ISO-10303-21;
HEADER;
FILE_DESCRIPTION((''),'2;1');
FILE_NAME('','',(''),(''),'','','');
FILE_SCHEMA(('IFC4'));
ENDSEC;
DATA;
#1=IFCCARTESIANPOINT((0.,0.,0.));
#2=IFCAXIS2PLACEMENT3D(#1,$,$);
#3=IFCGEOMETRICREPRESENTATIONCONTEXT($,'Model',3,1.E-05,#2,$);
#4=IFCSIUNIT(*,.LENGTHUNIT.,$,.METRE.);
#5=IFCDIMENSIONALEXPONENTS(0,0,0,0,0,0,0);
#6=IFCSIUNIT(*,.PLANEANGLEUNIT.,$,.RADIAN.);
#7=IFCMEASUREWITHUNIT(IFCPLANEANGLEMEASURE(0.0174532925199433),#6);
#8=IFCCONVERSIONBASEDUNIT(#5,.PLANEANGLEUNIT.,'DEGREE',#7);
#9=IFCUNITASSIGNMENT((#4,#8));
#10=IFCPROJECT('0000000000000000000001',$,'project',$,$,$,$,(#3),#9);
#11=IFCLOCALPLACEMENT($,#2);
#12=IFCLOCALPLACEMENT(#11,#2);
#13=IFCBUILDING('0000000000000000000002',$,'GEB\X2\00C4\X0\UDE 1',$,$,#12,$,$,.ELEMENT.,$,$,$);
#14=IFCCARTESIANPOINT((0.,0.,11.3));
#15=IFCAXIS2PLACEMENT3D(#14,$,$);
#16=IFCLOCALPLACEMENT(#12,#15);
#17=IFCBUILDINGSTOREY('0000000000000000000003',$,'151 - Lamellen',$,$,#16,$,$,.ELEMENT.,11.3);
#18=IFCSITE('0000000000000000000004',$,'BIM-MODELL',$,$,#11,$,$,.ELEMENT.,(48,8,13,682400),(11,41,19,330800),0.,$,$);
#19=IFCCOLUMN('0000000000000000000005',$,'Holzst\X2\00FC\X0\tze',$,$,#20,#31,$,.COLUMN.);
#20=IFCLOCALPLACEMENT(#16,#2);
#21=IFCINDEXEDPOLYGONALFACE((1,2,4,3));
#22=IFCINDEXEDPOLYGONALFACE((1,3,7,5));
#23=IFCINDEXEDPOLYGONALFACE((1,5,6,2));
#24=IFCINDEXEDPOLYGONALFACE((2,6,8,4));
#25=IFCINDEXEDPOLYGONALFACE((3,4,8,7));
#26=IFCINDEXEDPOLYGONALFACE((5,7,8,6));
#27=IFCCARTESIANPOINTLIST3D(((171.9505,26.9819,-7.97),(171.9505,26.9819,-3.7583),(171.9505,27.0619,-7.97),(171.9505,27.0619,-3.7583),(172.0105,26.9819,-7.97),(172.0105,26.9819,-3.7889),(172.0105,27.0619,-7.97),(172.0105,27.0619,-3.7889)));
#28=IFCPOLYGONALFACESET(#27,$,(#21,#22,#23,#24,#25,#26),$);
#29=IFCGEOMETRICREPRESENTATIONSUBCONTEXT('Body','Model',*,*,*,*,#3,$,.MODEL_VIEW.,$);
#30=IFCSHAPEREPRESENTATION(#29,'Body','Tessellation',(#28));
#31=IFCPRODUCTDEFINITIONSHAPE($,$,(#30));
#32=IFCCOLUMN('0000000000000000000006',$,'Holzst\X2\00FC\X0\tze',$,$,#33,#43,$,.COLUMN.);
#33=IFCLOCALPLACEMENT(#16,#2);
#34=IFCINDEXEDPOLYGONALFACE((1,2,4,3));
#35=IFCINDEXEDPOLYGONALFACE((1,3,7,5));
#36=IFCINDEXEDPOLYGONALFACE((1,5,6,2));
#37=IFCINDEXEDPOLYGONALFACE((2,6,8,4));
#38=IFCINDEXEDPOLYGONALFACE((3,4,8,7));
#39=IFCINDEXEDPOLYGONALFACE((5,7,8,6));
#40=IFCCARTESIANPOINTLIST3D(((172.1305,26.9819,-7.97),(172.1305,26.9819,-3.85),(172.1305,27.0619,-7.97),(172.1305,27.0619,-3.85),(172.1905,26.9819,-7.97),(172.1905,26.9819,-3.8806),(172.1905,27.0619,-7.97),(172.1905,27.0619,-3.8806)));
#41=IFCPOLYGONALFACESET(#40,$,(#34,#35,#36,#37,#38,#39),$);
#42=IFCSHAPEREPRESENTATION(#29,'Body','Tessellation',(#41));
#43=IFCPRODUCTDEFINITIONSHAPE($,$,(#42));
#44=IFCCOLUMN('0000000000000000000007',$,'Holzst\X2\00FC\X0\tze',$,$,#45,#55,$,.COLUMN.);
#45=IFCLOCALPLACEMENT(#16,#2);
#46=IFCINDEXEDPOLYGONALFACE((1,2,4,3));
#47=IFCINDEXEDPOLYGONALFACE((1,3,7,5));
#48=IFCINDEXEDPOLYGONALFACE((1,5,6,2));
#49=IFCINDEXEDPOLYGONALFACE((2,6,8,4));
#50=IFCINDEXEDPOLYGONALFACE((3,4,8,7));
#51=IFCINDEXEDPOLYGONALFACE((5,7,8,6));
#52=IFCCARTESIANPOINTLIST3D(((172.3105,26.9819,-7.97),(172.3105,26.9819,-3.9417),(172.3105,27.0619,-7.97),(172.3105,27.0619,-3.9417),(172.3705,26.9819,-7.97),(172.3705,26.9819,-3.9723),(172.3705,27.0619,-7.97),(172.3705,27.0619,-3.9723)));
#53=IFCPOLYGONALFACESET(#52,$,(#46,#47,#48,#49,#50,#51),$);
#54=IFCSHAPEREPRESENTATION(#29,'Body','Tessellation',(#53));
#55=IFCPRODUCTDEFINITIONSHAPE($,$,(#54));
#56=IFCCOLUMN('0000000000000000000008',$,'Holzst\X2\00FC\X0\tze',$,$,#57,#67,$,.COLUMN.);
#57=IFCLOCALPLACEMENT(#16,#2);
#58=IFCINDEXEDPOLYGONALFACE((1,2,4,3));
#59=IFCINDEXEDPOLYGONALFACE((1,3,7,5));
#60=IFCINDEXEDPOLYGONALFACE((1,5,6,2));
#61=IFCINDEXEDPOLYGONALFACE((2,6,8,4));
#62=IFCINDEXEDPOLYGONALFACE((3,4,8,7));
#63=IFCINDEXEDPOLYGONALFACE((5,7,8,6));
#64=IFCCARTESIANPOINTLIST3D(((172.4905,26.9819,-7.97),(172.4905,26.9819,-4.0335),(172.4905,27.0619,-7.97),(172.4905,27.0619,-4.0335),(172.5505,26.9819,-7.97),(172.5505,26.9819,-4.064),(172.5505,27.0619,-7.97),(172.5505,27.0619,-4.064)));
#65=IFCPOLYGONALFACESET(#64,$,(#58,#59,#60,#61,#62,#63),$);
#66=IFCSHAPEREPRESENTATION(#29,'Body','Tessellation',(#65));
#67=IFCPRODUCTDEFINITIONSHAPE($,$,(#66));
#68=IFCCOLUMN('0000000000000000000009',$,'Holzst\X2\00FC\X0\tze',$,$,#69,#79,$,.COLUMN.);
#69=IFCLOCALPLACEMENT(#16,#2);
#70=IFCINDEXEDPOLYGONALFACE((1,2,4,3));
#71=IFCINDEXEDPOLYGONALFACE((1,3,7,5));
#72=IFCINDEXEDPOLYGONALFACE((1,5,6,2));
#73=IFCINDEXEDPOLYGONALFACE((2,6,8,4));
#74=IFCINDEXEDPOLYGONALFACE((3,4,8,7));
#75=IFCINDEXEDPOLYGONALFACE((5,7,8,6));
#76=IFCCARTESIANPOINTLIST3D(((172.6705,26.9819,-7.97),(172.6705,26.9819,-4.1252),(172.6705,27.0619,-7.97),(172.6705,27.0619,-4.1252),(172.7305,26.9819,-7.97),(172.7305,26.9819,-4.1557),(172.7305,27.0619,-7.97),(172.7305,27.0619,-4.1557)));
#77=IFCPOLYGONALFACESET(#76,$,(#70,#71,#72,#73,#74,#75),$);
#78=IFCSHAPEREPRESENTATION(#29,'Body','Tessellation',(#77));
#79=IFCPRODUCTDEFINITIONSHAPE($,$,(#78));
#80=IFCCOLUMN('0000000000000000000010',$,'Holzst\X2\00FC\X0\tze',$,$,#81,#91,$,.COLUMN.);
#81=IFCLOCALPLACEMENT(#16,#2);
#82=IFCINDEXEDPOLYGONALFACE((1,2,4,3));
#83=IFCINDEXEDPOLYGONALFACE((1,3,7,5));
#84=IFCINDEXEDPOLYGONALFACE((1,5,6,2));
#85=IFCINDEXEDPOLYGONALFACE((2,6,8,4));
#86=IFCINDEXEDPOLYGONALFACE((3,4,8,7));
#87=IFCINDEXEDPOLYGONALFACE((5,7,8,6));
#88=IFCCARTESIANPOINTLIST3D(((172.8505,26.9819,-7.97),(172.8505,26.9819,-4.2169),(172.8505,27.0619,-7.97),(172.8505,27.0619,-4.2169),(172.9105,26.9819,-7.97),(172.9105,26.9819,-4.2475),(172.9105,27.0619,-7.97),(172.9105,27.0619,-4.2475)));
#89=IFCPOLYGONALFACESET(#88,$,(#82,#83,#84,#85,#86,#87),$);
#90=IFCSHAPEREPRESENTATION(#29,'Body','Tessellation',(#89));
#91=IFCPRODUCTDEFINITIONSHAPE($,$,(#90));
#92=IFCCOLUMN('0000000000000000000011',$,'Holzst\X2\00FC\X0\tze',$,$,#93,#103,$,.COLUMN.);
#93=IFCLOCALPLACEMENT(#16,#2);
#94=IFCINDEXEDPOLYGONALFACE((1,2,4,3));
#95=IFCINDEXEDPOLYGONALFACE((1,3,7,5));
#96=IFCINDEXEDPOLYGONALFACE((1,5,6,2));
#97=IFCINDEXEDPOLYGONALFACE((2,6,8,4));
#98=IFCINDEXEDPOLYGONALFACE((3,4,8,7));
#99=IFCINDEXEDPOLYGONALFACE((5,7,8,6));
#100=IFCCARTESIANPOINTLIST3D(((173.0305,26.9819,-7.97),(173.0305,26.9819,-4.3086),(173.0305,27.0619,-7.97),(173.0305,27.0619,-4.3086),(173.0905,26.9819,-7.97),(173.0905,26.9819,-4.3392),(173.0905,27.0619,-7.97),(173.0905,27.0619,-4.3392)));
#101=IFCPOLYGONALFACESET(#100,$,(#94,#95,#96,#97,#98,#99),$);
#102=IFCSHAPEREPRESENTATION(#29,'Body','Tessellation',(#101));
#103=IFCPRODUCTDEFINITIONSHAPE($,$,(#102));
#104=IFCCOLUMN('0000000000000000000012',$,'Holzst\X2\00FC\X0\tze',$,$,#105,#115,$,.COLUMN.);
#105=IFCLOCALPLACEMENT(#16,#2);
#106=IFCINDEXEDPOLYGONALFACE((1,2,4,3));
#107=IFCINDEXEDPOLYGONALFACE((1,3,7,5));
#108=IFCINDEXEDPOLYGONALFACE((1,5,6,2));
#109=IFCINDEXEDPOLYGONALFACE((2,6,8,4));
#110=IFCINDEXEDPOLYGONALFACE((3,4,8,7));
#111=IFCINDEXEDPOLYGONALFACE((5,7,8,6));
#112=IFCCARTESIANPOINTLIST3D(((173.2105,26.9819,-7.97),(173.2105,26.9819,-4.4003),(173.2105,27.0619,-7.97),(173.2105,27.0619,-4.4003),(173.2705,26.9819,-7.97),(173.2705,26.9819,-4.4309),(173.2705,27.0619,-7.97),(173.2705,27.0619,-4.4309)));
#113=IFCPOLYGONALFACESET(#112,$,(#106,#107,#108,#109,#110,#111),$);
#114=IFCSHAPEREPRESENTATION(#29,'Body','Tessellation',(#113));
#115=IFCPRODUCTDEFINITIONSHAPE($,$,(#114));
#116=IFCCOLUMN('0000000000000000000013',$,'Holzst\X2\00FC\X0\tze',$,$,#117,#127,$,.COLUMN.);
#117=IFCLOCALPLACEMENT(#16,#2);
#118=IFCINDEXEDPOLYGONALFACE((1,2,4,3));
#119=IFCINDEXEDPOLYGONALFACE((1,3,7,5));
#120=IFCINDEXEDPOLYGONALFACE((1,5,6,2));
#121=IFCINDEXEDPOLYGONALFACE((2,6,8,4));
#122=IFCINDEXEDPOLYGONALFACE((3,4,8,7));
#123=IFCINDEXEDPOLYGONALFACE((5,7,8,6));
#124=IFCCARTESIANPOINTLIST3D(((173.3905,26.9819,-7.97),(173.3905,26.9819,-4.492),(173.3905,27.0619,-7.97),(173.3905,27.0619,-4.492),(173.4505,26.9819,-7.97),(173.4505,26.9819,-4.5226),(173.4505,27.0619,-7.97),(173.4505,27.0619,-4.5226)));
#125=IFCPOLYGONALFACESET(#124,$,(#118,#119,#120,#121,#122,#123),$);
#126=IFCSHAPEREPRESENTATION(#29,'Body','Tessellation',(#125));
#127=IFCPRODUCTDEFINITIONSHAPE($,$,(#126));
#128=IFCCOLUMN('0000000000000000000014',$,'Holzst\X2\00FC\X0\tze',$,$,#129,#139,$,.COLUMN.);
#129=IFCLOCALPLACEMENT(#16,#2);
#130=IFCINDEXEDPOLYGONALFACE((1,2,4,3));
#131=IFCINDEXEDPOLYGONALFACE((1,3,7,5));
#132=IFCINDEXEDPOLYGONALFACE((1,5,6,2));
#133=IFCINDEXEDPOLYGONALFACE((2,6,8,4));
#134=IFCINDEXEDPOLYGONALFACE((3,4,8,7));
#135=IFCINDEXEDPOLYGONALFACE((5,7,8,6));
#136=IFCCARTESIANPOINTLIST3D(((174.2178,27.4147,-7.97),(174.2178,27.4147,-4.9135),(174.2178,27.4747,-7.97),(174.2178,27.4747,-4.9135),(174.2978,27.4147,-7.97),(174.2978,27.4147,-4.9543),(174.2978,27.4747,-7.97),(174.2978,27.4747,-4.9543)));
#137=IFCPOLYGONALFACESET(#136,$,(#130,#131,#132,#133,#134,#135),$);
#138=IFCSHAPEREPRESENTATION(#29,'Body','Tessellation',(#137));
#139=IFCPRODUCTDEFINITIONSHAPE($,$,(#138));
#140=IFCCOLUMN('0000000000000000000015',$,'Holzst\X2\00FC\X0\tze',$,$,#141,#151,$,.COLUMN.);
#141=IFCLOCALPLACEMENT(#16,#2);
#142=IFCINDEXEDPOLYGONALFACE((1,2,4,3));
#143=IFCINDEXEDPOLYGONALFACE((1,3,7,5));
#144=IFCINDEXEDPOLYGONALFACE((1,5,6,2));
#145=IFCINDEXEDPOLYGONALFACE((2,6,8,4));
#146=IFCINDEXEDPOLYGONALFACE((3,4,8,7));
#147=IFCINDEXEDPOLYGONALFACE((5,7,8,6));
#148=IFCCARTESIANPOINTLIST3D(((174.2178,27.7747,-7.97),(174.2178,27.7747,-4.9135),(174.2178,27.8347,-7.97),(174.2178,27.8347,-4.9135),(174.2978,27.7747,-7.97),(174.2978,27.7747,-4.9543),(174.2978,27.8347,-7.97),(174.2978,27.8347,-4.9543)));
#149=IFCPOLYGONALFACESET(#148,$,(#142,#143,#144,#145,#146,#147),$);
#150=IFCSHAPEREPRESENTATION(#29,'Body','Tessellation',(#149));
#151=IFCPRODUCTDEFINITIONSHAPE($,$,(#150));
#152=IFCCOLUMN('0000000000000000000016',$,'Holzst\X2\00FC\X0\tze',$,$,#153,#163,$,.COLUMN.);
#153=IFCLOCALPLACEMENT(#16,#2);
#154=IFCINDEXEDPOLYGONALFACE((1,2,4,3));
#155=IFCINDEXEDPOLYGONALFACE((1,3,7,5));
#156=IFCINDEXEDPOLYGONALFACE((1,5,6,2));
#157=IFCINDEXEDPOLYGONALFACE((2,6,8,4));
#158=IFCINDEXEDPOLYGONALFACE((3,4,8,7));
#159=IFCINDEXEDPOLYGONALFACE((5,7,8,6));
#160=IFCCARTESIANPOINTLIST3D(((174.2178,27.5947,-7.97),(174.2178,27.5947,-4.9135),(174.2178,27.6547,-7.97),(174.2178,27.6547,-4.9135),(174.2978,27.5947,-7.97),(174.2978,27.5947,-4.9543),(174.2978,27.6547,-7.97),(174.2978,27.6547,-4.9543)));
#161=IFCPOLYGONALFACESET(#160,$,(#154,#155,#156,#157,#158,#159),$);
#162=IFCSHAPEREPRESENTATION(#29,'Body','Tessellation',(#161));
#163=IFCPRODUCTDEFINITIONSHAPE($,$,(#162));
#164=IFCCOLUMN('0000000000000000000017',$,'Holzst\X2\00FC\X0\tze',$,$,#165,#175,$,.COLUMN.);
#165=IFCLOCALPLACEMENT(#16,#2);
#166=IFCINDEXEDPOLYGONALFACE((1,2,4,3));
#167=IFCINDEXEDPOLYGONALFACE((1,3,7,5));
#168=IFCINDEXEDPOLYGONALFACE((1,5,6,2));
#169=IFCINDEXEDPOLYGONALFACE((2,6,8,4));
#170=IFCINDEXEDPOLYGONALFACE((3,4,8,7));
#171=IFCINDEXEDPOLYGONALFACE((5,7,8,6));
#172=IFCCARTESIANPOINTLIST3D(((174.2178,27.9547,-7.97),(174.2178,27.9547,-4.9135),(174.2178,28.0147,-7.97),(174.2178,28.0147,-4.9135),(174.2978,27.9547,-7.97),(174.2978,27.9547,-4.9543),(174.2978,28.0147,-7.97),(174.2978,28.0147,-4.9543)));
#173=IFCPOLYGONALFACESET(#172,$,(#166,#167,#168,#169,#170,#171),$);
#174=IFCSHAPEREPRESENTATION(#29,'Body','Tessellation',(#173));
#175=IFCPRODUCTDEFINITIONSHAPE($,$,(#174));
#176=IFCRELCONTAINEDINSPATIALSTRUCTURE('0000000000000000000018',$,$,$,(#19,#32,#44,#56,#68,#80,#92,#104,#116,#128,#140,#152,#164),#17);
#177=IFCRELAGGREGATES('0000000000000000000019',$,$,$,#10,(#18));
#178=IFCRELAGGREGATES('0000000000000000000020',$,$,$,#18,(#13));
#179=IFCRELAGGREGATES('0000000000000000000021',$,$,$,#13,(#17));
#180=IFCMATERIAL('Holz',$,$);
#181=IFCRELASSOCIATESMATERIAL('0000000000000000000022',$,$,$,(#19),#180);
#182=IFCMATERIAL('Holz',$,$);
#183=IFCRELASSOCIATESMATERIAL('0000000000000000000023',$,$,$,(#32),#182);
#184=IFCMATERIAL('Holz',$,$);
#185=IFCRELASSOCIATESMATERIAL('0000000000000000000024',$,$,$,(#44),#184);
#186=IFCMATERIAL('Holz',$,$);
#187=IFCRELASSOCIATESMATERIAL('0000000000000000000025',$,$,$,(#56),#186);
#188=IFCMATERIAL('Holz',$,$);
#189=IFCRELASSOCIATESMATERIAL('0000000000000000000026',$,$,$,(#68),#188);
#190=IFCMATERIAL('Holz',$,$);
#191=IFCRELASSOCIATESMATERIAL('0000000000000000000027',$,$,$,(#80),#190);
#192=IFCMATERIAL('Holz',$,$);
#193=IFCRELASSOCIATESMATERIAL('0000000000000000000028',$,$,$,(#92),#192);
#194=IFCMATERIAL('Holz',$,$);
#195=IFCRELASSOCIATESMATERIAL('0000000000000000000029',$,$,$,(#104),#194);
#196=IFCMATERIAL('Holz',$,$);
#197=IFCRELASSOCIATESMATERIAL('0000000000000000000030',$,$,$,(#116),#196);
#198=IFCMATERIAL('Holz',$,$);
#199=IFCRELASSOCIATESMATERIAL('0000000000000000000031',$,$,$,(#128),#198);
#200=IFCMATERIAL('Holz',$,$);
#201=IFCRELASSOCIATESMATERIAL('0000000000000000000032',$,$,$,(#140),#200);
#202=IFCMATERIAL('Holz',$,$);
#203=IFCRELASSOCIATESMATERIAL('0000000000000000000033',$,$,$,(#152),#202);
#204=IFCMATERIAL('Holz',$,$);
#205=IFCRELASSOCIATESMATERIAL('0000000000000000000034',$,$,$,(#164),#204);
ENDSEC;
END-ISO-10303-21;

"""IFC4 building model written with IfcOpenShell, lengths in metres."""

from ifc_helpers import new_model, entity, si_unit, converted_unit, frame, frame_2d, origin, origin_with_axes, place, context, subcontext, project, spatial, rectangle, extrude, clip, halfspace, material, element, save


model = new_model("IFC4")

# Units and contexts
model_context = context("Model", 3, precision=1e-05, world=origin())
body_context = subcontext(model_context, "Body", "Model", "MODEL_VIEW")
ifc_project = project(units=[si_unit("LENGTHUNIT", "METRE"), converted_unit("PLANEANGLEUNIT", "DEGREE", entity("IfcPlaneAngleMeasure", 0.0174532925199433), si_unit("PLANEANGLEUNIT", "RADIAN"), dimensions=[0, 0, 0, 0, 0, 0, 0])], contexts=[model_context])

# Site, building, storey
site_placement = place(None, origin())
site = spatial("IfcSite", under=ifc_project, at=site_placement, Name="BIM-MODELL", CompositionType="ELEMENT", RefLatitude=(48, 8, 13, 682400), RefLongitude=(11, 41, 19, 330800), RefElevation=0.0)
building_placement = place(site_placement, origin())
building = spatial("IfcBuilding", under=site, at=building_placement, Name="GEBÄUDE 1", CompositionType="ELEMENT")
storey_placement = place(building_placement, frame((0.0, 0.0, 11.3)))
storey = spatial("IfcBuildingStorey", under=building, at=storey_placement, Name="151 - Lamellen", CompositionType="ELEMENT", Elevation=11.3)

# Columns
ifc_material_1 = material(Name="Holz")
column_1_placement = place(storey_placement, frame((171.9505, 26.9819, -7.97)))
element("IfcColumn", 1, at=column_1_placement, inside=storey, material=ifc_material_1, Name="Holzstütze", PredefinedType="COLUMN", context=body_context, shape_type="Clipping", body=[
    clip(extrude(rectangle(XDim=0.06, YDim=0.08, at=frame_2d((0.03, 0.04), x_axis=(1.0, 0.0))), origin_with_axes(), (0.0, 0.0, 1.0), 4.2117), halfspace(frame((0.03, 0.04, 4.1964), z_axis=(-0.45399, 0.0, -0.891007), x_axis=(0.0, -1.0, 0.0)), True)),
])
ifc_material_2 = material(Name="Holz")
column_2_placement = place(storey_placement, frame((172.1305, 26.9819, -7.97)))
element("IfcColumn", 2, at=column_2_placement, inside=storey, material=ifc_material_2, Name="Holzstütze", PredefinedType="COLUMN", context=body_context, shape_type="Clipping", body=[
    clip(extrude(rectangle(XDim=0.06, YDim=0.08, at=frame_2d((0.03, 0.04), x_axis=(1.0, 0.0))), origin_with_axes(), (0.0, 0.0, 1.0), 4.12), halfspace(frame((0.03, 0.04, 4.1047), z_axis=(-0.45399, 0.0, -0.891007), x_axis=(0.0, -1.0, 0.0)), True)),
])
ifc_material_3 = material(Name="Holz")
column_3_placement = place(storey_placement, frame((172.3105, 26.9819, -7.97)))
element("IfcColumn", 3, at=column_3_placement, inside=storey, material=ifc_material_3, Name="Holzstütze", PredefinedType="COLUMN", context=body_context, shape_type="Clipping", body=[
    clip(extrude(rectangle(XDim=0.06, YDim=0.08, at=frame_2d((0.03, 0.04), x_axis=(1.0, 0.0))), origin_with_axes(), (0.0, 0.0, 1.0), 4.0283), halfspace(frame((0.03, 0.04, 4.013), z_axis=(-0.45399, 0.0, -0.891007), x_axis=(0.0, -1.0, 0.0)), True)),
])
ifc_material_4 = material(Name="Holz")
column_4_placement = place(storey_placement, frame((172.4905, 26.9819, -7.97)))
element("IfcColumn", 4, at=column_4_placement, inside=storey, material=ifc_material_4, Name="Holzstütze", PredefinedType="COLUMN", context=body_context, shape_type="Clipping", body=[
    clip(extrude(rectangle(XDim=0.06, YDim=0.08, at=frame_2d((0.03, 0.04), x_axis=(1.0, 0.0))), origin_with_axes(), (0.0, 0.0, 1.0), 3.9365), halfspace(frame((0.03, 0.04, 3.9213), z_axis=(-0.45399, 0.0, -0.891007), x_axis=(0.0, -1.0, 0.0)), True)),
])
ifc_material_5 = material(Name="Holz")
column_5_placement = place(storey_placement, frame((172.6705, 26.9819, -7.97)))
element("IfcColumn", 5, at=column_5_placement, inside=storey, material=ifc_material_5, Name="Holzstütze", PredefinedType="COLUMN", context=body_context, shape_type="Clipping", body=[
    clip(extrude(rectangle(XDim=0.06, YDim=0.08, at=frame_2d((0.03, 0.04), x_axis=(1.0, 0.0))), origin_with_axes(), (0.0, 0.0, 1.0), 3.8448), halfspace(frame((0.03, 0.04, 3.8295), z_axis=(-0.45399, 0.0, -0.891007), x_axis=(0.0, -1.0, 0.0)), True)),
])
ifc_material_6 = material(Name="Holz")
column_6_placement = place(storey_placement, frame((172.8505, 26.9819, -7.97)))
element("IfcColumn", 6, at=column_6_placement, inside=storey, material=ifc_material_6, Name="Holzstütze", PredefinedType="COLUMN", context=body_context, shape_type="Clipping", body=[
    clip(extrude(rectangle(XDim=0.06, YDim=0.08, at=frame_2d((0.03, 0.04), x_axis=(1.0, 0.0))), origin_with_axes(), (0.0, 0.0, 1.0), 3.7531), halfspace(frame((0.03, 0.04, 3.7378), z_axis=(-0.45399, 0.0, -0.891007), x_axis=(0.0, -1.0, 0.0)), True)),
])
ifc_material_7 = material(Name="Holz")
column_7_placement = place(storey_placement, frame((173.0305, 26.9819, -7.97)))
element("IfcColumn", 7, at=column_7_placement, inside=storey, material=ifc_material_7, Name="Holzstütze", PredefinedType="COLUMN", context=body_context, shape_type="Clipping", body=[
    clip(extrude(rectangle(XDim=0.06, YDim=0.08, at=frame_2d((0.03, 0.04), x_axis=(1.0, 0.0))), origin_with_axes(), (0.0, 0.0, 1.0), 3.6614), halfspace(frame((0.03, 0.04, 3.6461), z_axis=(-0.45399, 0.0, -0.891007), x_axis=(0.0, -1.0, 0.0)), True)),
])
ifc_material_8 = material(Name="Holz")
column_8_placement = place(storey_placement, frame((173.2105, 26.9819, -7.97)))
element("IfcColumn", 8, at=column_8_placement, inside=storey, material=ifc_material_8, Name="Holzstütze", PredefinedType="COLUMN", context=body_context, shape_type="Clipping", body=[
    clip(extrude(rectangle(XDim=0.06, YDim=0.08, at=frame_2d((0.03, 0.04), x_axis=(1.0, 0.0))), origin_with_axes(), (0.0, 0.0, 1.0), 3.5697), halfspace(frame((0.03, 0.04, 3.5544), z_axis=(-0.45399, 0.0, -0.891007), x_axis=(0.0, -1.0, 0.0)), True)),
])
ifc_material_9 = material(Name="Holz")
column_9_placement = place(storey_placement, frame((173.3905, 26.9819, -7.97)))
element("IfcColumn", 9, at=column_9_placement, inside=storey, material=ifc_material_9, Name="Holzstütze", PredefinedType="COLUMN", context=body_context, shape_type="Clipping", body=[
    clip(extrude(rectangle(XDim=0.06, YDim=0.08, at=frame_2d((0.03, 0.04), x_axis=(1.0, 0.0))), origin_with_axes(), (0.0, 0.0, 1.0), 3.478), halfspace(frame((0.03, 0.04, 3.4627), z_axis=(-0.45399, 0.0, -0.891007), x_axis=(0.0, -1.0, 0.0)), True)),
])
ifc_material_10 = material(Name="Holz")
column_10_placement = place(storey_placement, frame((174.2978, 27.4147, -7.97)))
element("IfcColumn", 10, at=column_10_placement, inside=storey, material=ifc_material_10, Name="Holzstütze", PredefinedType="COLUMN", context=body_context, shape_type="Clipping", body=[
    clip(extrude(rectangle(XDim=0.06, YDim=0.08, at=frame_2d((-0.04, 0.03), x_axis=(0.0, 1.0))), origin_with_axes(), (0.0, 0.0, 1.0), 3.0565), halfspace(frame((-0.04, 0.03, 3.0361), z_axis=(-0.45399, 0.0, -0.891007), x_axis=(0.891007, 0.0, -0.45399)), True)),
])
ifc_material_11 = material(Name="Holz")
column_11_placement = place(storey_placement, frame((174.2978, 27.7747, -7.97)))
element("IfcColumn", 11, at=column_11_placement, inside=storey, material=ifc_material_11, Name="Holzstütze", PredefinedType="COLUMN", context=body_context, shape_type="Clipping", body=[
    clip(extrude(rectangle(XDim=0.06, YDim=0.08, at=frame_2d((-0.04, 0.03), x_axis=(0.0, 1.0))), origin_with_axes(), (0.0, 0.0, 1.0), 3.0565), halfspace(frame((-0.04, 0.03, 3.0361), z_axis=(-0.45399, 0.0, -0.891007), x_axis=(0.891007, 0.0, -0.45399)), True)),
])
ifc_material_12 = material(Name="Holz")
column_12_placement = place(storey_placement, frame((174.2978, 27.5947, -7.97)))
element("IfcColumn", 12, at=column_12_placement, inside=storey, material=ifc_material_12, Name="Holzstütze", PredefinedType="COLUMN", context=body_context, shape_type="Clipping", body=[
    clip(extrude(rectangle(XDim=0.06, YDim=0.08, at=frame_2d((-0.04, 0.03), x_axis=(0.0, 1.0))), origin_with_axes(), (0.0, 0.0, 1.0), 3.0565), halfspace(frame((-0.04, 0.03, 3.0361), z_axis=(-0.45399, 0.0, -0.891007), x_axis=(0.891007, 0.0, -0.45399)), True)),
])
ifc_material_13 = material(Name="Holz")
column_13_placement = place(storey_placement, frame((174.2978, 27.9547, -7.97)))
element("IfcColumn", 13, at=column_13_placement, inside=storey, material=ifc_material_13, Name="Holzstütze", PredefinedType="COLUMN", context=body_context, shape_type="Clipping", body=[
    clip(extrude(rectangle(XDim=0.06, YDim=0.08, at=frame_2d((-0.04, 0.03), x_axis=(0.0, 1.0))), origin_with_axes(), (0.0, 0.0, 1.0), 3.0565), halfspace(frame((-0.04, 0.03, 3.0361), z_axis=(-0.45399, 0.0, -0.891007), x_axis=(0.891007, 0.0, -0.45399)), True)),
])

save(model, "model.ifc")
